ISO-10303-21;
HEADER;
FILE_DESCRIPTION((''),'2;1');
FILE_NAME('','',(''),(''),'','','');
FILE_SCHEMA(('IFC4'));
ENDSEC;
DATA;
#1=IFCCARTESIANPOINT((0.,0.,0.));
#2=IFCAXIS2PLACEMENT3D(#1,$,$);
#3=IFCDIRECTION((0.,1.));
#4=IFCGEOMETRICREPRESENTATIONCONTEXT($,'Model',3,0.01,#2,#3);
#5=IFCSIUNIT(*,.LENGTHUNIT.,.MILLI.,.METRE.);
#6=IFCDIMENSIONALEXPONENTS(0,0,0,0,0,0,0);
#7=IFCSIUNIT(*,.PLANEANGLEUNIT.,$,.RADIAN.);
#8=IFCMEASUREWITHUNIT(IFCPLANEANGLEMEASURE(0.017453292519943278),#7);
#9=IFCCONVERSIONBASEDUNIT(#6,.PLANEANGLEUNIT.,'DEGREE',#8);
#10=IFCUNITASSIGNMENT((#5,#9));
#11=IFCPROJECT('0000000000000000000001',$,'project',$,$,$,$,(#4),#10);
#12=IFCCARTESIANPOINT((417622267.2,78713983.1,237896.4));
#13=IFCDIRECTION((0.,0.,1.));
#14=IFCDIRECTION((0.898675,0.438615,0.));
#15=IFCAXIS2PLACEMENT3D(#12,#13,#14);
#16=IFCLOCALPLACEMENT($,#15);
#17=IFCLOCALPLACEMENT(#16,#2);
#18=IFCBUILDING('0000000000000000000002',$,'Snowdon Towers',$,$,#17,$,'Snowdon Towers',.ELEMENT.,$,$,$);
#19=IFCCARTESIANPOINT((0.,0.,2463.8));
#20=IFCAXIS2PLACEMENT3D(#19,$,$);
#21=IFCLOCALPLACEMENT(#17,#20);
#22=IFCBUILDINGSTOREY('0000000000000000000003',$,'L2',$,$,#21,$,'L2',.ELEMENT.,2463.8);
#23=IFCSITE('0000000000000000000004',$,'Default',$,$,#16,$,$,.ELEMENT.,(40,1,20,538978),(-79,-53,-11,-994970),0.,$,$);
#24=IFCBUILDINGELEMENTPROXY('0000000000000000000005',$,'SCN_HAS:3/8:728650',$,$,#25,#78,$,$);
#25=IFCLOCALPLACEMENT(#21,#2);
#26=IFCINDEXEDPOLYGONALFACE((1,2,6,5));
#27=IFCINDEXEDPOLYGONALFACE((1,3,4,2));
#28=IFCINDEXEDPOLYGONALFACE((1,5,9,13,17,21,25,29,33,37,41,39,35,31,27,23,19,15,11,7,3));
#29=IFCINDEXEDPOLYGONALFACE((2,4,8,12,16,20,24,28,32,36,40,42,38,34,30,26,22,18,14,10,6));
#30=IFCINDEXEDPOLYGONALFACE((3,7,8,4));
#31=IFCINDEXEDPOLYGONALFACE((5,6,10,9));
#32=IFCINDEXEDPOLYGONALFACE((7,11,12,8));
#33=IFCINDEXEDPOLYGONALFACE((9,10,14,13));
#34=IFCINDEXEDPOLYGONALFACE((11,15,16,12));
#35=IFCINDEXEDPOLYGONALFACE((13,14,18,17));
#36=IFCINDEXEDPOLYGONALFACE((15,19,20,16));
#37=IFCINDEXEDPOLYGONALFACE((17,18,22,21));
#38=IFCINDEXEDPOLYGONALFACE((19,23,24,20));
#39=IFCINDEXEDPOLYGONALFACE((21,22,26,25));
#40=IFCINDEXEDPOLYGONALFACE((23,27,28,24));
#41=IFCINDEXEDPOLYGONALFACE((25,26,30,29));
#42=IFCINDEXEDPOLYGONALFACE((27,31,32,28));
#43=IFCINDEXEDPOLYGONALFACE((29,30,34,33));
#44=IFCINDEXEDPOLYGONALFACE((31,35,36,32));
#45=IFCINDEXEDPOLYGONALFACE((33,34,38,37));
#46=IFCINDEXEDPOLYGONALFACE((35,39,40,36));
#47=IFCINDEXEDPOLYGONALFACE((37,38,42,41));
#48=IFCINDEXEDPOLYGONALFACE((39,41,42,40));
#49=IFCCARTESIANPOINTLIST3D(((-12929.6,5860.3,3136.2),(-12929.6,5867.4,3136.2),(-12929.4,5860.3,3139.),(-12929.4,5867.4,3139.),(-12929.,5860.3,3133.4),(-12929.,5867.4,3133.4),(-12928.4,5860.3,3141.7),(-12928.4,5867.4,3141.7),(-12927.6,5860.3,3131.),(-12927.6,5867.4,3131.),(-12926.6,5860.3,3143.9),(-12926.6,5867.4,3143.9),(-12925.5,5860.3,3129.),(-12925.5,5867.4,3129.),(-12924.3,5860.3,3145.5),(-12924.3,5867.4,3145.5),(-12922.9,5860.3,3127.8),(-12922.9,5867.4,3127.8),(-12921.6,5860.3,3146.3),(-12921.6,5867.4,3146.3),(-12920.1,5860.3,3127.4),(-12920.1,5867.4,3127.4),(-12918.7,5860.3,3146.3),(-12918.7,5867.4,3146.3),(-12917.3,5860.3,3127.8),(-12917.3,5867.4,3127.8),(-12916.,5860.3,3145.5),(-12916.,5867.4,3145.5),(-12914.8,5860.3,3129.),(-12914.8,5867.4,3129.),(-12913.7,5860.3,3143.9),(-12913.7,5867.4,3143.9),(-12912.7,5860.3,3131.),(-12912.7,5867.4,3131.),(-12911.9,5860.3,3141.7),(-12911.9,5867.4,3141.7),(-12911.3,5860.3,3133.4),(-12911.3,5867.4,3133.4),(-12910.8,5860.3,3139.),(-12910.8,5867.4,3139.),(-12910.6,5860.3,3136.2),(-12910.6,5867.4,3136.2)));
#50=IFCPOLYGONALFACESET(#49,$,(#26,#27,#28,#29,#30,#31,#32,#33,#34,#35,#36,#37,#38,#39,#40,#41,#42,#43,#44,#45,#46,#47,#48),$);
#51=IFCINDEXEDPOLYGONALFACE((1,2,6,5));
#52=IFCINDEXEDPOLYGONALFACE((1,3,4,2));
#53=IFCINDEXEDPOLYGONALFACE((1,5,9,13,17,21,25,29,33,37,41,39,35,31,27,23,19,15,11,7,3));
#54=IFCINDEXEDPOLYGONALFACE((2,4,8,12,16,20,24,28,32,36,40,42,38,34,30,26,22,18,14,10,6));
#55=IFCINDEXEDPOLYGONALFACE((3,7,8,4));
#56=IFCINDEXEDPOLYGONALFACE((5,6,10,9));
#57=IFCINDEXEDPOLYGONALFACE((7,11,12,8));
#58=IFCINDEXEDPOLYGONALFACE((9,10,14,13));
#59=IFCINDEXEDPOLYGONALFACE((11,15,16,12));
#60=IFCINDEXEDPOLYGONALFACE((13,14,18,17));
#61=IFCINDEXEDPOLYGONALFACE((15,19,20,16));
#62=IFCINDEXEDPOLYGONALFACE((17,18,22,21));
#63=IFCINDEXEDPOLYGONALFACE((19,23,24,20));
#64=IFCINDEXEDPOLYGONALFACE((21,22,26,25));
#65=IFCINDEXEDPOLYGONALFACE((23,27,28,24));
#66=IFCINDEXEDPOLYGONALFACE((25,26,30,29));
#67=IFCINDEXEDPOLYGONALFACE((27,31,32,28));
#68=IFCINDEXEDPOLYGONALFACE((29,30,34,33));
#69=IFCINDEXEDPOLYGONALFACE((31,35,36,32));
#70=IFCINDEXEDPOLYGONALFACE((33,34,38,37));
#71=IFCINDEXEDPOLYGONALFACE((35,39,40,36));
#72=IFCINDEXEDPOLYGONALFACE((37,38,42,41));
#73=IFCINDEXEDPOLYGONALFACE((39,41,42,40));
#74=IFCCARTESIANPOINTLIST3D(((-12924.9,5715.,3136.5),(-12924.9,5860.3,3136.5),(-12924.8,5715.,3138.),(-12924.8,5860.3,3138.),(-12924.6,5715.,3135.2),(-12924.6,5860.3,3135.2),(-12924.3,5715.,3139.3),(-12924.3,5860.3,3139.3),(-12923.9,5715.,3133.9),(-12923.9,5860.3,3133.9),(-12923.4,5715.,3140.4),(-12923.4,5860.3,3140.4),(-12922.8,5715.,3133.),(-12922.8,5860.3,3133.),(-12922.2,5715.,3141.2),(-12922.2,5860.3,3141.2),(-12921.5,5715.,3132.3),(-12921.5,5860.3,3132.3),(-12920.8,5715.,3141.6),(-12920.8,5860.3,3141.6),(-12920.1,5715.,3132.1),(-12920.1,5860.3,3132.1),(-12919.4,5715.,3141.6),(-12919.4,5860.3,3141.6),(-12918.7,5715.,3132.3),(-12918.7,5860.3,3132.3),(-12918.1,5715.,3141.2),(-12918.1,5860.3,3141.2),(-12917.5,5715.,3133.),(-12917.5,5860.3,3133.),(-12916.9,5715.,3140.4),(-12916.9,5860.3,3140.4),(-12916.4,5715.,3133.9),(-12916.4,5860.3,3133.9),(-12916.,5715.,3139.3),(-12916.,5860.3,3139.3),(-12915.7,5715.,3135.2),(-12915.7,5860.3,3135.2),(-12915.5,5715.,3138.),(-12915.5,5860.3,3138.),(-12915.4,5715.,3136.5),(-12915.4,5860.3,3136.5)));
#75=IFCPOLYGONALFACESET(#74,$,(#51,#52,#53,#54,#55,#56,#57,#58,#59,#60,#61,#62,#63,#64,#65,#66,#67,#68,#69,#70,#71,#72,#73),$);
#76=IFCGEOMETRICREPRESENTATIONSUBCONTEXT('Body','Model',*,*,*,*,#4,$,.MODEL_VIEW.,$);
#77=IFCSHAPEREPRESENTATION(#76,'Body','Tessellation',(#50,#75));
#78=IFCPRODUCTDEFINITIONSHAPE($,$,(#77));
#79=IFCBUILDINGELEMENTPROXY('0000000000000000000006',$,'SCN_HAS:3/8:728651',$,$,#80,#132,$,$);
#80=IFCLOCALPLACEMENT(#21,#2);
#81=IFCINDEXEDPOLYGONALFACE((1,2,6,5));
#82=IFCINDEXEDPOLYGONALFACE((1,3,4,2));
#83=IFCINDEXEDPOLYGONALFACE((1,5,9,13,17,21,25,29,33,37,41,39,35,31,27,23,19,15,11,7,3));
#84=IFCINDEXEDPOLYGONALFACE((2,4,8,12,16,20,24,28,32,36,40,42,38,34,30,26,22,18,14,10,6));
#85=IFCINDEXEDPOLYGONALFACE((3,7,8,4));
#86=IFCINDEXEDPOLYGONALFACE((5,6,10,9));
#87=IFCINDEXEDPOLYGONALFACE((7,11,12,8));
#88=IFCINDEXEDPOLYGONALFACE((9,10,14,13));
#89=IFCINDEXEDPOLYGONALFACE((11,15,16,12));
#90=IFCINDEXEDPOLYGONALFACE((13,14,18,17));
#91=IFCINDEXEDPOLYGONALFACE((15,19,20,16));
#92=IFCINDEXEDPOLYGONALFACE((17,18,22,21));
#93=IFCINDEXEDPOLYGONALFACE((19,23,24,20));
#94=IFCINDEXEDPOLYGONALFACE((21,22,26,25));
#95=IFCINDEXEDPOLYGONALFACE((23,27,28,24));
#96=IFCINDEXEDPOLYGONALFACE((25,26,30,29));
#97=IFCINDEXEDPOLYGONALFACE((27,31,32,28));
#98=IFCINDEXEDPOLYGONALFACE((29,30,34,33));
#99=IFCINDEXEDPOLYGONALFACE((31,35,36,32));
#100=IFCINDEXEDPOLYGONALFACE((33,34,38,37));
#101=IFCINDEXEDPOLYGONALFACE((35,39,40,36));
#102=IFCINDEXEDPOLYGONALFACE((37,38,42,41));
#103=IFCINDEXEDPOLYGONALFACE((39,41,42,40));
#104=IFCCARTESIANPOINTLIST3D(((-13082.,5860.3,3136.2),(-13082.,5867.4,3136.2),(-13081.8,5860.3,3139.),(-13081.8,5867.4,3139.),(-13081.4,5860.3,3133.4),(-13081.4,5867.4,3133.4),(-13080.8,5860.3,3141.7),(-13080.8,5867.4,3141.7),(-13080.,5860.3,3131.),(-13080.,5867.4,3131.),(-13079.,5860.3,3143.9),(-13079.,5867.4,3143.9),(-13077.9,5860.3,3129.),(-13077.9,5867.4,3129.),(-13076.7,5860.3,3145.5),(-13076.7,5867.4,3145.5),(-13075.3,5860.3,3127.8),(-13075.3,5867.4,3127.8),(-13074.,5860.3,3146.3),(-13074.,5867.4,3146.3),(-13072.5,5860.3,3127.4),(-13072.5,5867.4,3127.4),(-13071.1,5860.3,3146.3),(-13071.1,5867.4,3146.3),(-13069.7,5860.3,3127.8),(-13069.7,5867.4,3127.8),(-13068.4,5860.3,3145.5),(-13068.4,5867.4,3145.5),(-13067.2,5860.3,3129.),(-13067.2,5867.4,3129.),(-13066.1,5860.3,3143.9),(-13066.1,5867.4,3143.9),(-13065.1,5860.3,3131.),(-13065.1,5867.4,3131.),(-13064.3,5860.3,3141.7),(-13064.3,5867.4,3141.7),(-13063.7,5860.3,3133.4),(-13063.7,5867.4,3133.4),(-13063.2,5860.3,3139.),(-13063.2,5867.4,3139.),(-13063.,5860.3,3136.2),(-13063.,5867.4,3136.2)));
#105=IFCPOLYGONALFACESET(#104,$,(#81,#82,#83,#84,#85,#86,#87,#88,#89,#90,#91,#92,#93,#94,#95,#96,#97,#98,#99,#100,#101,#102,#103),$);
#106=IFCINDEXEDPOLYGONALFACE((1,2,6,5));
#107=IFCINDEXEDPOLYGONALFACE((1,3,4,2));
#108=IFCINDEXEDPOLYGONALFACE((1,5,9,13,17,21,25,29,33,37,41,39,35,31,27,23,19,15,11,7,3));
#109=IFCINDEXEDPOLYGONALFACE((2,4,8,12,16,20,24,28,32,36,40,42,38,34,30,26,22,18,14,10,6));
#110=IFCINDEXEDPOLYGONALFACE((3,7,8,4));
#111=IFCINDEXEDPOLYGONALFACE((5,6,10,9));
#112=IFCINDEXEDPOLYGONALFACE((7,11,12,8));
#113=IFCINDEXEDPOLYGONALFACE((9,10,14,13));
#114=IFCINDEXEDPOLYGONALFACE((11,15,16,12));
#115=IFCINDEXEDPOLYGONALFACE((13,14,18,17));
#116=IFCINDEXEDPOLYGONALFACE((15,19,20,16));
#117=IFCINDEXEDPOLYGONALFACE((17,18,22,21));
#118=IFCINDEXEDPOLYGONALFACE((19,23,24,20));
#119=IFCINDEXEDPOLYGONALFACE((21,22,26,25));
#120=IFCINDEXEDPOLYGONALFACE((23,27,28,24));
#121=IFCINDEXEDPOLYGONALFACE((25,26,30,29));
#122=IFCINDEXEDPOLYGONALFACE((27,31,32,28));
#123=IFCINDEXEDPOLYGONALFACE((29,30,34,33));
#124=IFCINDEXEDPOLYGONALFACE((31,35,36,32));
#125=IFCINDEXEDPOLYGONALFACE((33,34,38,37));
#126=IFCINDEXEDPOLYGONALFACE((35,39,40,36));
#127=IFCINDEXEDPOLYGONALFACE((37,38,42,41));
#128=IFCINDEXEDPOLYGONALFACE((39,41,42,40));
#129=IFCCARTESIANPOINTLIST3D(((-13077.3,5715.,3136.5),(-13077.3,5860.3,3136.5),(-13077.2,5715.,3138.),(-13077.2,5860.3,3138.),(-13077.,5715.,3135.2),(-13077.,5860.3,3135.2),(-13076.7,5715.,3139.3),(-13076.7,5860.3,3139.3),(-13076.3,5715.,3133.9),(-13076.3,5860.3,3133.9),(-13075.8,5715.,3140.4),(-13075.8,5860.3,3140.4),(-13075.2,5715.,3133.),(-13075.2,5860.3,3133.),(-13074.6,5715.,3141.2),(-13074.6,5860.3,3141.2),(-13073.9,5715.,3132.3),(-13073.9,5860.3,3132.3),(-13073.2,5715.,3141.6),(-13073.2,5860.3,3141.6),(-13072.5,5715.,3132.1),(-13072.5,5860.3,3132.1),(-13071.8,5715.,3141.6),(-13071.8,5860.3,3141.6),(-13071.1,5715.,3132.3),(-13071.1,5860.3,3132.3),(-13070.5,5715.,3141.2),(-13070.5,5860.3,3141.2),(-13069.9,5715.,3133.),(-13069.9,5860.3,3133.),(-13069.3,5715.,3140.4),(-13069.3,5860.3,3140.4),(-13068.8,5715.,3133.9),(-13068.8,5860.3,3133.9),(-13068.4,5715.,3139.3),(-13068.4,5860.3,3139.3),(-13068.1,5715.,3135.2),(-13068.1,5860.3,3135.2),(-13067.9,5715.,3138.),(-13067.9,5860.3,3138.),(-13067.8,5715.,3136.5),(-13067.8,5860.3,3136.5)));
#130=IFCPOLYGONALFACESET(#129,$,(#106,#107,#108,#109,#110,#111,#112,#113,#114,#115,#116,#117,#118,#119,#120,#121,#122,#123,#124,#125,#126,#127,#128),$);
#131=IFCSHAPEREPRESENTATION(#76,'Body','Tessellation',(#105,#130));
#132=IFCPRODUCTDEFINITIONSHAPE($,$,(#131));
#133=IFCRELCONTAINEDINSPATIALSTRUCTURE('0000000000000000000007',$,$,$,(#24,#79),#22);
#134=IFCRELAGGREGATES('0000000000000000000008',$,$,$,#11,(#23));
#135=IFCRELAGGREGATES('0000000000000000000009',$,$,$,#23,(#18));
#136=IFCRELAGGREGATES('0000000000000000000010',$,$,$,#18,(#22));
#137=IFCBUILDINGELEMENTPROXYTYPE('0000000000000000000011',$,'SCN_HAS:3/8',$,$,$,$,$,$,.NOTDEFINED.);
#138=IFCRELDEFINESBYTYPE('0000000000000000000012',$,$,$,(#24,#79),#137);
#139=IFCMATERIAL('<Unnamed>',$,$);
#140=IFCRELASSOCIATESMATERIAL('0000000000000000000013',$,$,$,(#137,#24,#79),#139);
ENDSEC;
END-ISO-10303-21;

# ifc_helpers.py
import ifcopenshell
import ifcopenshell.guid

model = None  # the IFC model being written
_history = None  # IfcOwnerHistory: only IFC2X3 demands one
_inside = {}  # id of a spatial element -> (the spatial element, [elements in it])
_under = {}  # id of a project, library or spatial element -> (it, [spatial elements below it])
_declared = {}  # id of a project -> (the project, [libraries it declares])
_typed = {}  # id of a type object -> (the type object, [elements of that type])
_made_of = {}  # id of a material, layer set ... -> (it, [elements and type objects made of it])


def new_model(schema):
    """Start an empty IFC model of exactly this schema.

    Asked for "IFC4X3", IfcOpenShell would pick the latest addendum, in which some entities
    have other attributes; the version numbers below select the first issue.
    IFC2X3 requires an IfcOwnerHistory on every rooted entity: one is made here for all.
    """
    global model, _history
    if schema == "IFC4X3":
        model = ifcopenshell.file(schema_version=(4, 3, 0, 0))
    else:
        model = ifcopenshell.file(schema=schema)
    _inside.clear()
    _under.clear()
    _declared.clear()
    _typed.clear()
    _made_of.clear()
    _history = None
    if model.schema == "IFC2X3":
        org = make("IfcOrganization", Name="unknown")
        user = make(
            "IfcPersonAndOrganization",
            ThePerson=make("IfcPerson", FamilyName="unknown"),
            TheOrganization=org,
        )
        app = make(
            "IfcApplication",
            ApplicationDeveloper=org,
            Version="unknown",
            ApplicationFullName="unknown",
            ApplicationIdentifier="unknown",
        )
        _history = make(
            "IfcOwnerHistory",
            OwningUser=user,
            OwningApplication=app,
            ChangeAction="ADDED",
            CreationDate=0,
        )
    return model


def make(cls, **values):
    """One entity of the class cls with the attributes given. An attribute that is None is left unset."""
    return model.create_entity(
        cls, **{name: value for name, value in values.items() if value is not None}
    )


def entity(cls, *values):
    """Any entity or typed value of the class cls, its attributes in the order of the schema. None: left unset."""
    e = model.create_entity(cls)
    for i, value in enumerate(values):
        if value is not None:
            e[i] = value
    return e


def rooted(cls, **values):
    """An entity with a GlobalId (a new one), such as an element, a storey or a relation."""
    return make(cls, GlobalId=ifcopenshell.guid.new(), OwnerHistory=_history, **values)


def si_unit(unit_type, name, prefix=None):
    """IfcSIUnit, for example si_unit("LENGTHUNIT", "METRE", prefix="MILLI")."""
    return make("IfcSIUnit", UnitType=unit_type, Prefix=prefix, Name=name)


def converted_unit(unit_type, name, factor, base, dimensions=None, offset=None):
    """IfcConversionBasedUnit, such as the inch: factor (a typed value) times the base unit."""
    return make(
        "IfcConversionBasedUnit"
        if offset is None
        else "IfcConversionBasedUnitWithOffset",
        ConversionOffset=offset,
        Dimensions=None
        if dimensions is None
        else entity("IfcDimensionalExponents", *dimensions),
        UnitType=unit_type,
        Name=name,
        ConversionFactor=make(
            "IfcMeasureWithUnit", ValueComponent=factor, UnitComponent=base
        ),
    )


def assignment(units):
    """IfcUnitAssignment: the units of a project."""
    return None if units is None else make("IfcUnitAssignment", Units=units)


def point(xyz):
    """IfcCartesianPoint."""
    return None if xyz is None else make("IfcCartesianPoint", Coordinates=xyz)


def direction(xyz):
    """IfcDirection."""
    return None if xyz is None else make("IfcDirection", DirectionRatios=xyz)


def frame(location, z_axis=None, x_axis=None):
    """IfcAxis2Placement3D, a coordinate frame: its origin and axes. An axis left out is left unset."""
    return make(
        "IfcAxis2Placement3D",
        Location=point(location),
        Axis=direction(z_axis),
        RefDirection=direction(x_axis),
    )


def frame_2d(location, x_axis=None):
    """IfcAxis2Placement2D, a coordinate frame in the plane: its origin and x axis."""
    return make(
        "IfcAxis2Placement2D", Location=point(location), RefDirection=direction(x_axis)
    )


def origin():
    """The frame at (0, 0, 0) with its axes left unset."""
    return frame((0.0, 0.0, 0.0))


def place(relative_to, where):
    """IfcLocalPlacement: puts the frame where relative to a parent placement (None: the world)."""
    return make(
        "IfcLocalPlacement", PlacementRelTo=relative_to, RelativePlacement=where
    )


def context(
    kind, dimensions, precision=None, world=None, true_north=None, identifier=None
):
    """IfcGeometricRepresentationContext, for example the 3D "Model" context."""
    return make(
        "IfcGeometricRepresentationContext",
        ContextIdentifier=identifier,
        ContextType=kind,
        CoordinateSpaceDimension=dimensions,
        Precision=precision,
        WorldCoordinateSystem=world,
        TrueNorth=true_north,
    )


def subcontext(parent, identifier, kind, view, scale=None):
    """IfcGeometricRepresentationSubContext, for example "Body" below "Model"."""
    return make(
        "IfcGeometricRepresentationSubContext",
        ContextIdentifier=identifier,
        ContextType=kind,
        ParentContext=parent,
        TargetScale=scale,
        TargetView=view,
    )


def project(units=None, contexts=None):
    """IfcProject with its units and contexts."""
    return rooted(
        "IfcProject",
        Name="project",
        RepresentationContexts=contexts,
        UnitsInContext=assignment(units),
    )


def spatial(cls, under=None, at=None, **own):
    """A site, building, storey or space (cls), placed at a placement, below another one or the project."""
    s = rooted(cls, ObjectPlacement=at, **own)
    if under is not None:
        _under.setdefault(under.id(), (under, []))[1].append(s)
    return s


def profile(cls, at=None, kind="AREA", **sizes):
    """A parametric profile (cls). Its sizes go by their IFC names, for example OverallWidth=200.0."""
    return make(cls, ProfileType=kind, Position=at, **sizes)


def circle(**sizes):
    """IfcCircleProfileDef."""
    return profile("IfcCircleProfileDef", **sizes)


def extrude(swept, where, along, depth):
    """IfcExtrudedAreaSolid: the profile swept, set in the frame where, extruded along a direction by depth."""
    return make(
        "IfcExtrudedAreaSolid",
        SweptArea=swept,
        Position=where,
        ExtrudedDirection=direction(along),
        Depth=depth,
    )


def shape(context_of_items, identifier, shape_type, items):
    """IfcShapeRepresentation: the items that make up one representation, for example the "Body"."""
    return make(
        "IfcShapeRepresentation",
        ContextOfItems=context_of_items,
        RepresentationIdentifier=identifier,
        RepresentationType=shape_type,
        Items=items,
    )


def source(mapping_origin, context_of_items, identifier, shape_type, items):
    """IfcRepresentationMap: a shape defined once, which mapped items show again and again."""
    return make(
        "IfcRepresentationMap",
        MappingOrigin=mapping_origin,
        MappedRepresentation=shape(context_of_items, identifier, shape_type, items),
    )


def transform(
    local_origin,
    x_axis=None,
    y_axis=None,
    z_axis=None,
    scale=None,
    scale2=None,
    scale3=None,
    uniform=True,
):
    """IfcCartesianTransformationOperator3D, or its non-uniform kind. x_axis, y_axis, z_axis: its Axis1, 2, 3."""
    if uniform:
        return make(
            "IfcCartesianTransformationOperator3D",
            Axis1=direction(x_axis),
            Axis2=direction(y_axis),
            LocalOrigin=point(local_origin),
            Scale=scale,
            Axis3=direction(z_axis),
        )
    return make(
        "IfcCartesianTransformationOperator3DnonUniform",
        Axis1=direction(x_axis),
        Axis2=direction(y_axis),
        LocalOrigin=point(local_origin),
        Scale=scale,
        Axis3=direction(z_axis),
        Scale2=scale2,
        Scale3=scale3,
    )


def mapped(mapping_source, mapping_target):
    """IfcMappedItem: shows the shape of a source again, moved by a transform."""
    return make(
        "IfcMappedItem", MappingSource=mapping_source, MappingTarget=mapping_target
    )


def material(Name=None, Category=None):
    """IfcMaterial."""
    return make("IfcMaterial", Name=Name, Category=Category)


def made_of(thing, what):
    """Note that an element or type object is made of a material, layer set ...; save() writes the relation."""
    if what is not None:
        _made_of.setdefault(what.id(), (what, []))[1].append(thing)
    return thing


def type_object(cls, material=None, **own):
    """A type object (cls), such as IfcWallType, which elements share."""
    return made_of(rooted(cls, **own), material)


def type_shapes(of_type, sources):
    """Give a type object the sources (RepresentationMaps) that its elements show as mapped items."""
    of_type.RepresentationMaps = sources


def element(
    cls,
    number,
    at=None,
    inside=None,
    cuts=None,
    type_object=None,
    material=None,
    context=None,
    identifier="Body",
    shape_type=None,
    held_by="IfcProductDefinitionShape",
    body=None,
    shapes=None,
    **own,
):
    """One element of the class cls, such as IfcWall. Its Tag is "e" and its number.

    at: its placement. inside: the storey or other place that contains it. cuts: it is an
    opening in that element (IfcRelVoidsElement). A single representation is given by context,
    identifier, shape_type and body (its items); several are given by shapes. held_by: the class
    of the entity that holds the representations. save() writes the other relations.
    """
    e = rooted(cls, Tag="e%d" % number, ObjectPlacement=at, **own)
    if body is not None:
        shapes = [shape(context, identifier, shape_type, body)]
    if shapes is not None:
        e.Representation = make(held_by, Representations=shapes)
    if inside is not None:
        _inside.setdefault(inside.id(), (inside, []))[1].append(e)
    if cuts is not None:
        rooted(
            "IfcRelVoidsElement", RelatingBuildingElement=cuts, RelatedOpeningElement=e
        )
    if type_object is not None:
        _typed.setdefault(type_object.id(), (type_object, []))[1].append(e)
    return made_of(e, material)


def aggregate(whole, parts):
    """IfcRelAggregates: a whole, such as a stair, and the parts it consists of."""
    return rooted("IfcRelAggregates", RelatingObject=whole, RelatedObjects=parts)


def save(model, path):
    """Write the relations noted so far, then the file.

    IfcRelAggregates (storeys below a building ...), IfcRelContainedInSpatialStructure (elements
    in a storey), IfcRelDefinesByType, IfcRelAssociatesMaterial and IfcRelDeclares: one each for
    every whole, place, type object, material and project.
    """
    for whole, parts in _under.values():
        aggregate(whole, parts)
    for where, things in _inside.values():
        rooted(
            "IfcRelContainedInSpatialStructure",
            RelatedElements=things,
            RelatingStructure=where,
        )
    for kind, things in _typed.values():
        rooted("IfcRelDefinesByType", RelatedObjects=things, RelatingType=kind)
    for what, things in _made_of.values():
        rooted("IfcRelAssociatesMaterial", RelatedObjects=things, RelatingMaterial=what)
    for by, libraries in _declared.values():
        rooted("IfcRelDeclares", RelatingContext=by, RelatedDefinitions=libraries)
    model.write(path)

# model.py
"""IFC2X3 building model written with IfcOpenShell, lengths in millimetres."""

from ifc_helpers import new_model, entity, si_unit, converted_unit, direction, frame, frame_2d, origin, place, context, subcontext, project, spatial, circle, extrude, source, transform, mapped, material, type_object, type_shapes, element, save


model = new_model("IFC2X3")

# Units and contexts
model_context = context("Model", 3, precision=0.01, world=origin(), true_north=direction((0.0, 1.0)))
body_context = subcontext(model_context, "Body", "Model", "MODEL_VIEW")
ifc_project = project(units=[si_unit("LENGTHUNIT", "METRE", prefix="MILLI"), converted_unit("PLANEANGLEUNIT", "DEGREE", entity("IfcPlaneAngleMeasure", 0.017453292519943278), si_unit("PLANEANGLEUNIT", "RADIAN"), dimensions=[0, 0, 0, 0, 0, 0, 0])], contexts=[model_context])

# Site, building, storey
site_placement = place(None, frame((417622267.2, 78713983.1, 237896.4), z_axis=(0.0, 0.0, 1.0), x_axis=(0.898675, 0.438615, 0.0)))
site = spatial("IfcSite", under=ifc_project, at=site_placement, Name="Default", CompositionType="ELEMENT", RefLatitude=(40, 1, 20, 538978), RefLongitude=(-79, -53, -11, -994970), RefElevation=0.0)
building_placement = place(site_placement, origin())
building = spatial("IfcBuilding", under=site, at=building_placement, Name="Snowdon Towers", LongName="Snowdon Towers", CompositionType="ELEMENT")
storey_placement = place(building_placement, frame((0.0, 0.0, 2463.8)))
storey = spatial("IfcBuildingStorey", under=building, at=storey_placement, Name="L2", LongName="L2", CompositionType="ELEMENT", Elevation=2463.8)

# Building element proxies
ifc_material_1 = material(Name="<Unnamed>")
building_element_proxy_type_1 = type_object("IfcBuildingElementProxyType", Name="SCN_HAS:3/8", PredefinedType="NOTDEFINED", material=ifc_material_1)
shared_shape_1 = source(origin(), body_context, "Body", "SweptSolid", [
    extrude(circle(Radius=9.5, at=frame_2d((0.0, 0.0), x_axis=(1.0, 0.0))), frame((0.0, 0.0, -152.4), z_axis=(0.0, 0.0, 1.0), x_axis=(0.0, -1.0, 0.0)), (0.0, 0.0, 1.0), 7.1),
    extrude(circle(Radius=4.8, at=frame_2d((0.0, 0.0), x_axis=(1.0, 0.0))), frame((0.0, 0.0, -145.3), z_axis=(0.0, 0.0, 1.0), x_axis=(0.0, -1.0, 0.0)), (0.0, 0.0, 1.0), 145.3),
])
type_shapes(building_element_proxy_type_1, [shared_shape_1])
for number, where, z_axis, x_axis, name in (
    (1, (-12920.1, 5715.0, 3136.9), (0.0, -1.0, 0.0), (1.0, 0.0, 0.0), "SCN_HAS:3/8:728650"),
    (2, (-13072.5, 5715.0, 3136.9), (0.0, -1.0, 0.0), (1.0, 0.0, 0.0), "SCN_HAS:3/8:728651"),
):
    element("IfcBuildingElementProxy", number, at=place(storey_placement, frame(where, z_axis=z_axis, x_axis=x_axis)), inside=storey, type_object=building_element_proxy_type_1, material=ifc_material_1, Name=name, context=body_context, shape_type="MappedRepresentation", body=[
        mapped(shared_shape_1, transform((0.0, 0.0, 0.0), scale=1.0)),
    ])

save(model, "model.ifc")
